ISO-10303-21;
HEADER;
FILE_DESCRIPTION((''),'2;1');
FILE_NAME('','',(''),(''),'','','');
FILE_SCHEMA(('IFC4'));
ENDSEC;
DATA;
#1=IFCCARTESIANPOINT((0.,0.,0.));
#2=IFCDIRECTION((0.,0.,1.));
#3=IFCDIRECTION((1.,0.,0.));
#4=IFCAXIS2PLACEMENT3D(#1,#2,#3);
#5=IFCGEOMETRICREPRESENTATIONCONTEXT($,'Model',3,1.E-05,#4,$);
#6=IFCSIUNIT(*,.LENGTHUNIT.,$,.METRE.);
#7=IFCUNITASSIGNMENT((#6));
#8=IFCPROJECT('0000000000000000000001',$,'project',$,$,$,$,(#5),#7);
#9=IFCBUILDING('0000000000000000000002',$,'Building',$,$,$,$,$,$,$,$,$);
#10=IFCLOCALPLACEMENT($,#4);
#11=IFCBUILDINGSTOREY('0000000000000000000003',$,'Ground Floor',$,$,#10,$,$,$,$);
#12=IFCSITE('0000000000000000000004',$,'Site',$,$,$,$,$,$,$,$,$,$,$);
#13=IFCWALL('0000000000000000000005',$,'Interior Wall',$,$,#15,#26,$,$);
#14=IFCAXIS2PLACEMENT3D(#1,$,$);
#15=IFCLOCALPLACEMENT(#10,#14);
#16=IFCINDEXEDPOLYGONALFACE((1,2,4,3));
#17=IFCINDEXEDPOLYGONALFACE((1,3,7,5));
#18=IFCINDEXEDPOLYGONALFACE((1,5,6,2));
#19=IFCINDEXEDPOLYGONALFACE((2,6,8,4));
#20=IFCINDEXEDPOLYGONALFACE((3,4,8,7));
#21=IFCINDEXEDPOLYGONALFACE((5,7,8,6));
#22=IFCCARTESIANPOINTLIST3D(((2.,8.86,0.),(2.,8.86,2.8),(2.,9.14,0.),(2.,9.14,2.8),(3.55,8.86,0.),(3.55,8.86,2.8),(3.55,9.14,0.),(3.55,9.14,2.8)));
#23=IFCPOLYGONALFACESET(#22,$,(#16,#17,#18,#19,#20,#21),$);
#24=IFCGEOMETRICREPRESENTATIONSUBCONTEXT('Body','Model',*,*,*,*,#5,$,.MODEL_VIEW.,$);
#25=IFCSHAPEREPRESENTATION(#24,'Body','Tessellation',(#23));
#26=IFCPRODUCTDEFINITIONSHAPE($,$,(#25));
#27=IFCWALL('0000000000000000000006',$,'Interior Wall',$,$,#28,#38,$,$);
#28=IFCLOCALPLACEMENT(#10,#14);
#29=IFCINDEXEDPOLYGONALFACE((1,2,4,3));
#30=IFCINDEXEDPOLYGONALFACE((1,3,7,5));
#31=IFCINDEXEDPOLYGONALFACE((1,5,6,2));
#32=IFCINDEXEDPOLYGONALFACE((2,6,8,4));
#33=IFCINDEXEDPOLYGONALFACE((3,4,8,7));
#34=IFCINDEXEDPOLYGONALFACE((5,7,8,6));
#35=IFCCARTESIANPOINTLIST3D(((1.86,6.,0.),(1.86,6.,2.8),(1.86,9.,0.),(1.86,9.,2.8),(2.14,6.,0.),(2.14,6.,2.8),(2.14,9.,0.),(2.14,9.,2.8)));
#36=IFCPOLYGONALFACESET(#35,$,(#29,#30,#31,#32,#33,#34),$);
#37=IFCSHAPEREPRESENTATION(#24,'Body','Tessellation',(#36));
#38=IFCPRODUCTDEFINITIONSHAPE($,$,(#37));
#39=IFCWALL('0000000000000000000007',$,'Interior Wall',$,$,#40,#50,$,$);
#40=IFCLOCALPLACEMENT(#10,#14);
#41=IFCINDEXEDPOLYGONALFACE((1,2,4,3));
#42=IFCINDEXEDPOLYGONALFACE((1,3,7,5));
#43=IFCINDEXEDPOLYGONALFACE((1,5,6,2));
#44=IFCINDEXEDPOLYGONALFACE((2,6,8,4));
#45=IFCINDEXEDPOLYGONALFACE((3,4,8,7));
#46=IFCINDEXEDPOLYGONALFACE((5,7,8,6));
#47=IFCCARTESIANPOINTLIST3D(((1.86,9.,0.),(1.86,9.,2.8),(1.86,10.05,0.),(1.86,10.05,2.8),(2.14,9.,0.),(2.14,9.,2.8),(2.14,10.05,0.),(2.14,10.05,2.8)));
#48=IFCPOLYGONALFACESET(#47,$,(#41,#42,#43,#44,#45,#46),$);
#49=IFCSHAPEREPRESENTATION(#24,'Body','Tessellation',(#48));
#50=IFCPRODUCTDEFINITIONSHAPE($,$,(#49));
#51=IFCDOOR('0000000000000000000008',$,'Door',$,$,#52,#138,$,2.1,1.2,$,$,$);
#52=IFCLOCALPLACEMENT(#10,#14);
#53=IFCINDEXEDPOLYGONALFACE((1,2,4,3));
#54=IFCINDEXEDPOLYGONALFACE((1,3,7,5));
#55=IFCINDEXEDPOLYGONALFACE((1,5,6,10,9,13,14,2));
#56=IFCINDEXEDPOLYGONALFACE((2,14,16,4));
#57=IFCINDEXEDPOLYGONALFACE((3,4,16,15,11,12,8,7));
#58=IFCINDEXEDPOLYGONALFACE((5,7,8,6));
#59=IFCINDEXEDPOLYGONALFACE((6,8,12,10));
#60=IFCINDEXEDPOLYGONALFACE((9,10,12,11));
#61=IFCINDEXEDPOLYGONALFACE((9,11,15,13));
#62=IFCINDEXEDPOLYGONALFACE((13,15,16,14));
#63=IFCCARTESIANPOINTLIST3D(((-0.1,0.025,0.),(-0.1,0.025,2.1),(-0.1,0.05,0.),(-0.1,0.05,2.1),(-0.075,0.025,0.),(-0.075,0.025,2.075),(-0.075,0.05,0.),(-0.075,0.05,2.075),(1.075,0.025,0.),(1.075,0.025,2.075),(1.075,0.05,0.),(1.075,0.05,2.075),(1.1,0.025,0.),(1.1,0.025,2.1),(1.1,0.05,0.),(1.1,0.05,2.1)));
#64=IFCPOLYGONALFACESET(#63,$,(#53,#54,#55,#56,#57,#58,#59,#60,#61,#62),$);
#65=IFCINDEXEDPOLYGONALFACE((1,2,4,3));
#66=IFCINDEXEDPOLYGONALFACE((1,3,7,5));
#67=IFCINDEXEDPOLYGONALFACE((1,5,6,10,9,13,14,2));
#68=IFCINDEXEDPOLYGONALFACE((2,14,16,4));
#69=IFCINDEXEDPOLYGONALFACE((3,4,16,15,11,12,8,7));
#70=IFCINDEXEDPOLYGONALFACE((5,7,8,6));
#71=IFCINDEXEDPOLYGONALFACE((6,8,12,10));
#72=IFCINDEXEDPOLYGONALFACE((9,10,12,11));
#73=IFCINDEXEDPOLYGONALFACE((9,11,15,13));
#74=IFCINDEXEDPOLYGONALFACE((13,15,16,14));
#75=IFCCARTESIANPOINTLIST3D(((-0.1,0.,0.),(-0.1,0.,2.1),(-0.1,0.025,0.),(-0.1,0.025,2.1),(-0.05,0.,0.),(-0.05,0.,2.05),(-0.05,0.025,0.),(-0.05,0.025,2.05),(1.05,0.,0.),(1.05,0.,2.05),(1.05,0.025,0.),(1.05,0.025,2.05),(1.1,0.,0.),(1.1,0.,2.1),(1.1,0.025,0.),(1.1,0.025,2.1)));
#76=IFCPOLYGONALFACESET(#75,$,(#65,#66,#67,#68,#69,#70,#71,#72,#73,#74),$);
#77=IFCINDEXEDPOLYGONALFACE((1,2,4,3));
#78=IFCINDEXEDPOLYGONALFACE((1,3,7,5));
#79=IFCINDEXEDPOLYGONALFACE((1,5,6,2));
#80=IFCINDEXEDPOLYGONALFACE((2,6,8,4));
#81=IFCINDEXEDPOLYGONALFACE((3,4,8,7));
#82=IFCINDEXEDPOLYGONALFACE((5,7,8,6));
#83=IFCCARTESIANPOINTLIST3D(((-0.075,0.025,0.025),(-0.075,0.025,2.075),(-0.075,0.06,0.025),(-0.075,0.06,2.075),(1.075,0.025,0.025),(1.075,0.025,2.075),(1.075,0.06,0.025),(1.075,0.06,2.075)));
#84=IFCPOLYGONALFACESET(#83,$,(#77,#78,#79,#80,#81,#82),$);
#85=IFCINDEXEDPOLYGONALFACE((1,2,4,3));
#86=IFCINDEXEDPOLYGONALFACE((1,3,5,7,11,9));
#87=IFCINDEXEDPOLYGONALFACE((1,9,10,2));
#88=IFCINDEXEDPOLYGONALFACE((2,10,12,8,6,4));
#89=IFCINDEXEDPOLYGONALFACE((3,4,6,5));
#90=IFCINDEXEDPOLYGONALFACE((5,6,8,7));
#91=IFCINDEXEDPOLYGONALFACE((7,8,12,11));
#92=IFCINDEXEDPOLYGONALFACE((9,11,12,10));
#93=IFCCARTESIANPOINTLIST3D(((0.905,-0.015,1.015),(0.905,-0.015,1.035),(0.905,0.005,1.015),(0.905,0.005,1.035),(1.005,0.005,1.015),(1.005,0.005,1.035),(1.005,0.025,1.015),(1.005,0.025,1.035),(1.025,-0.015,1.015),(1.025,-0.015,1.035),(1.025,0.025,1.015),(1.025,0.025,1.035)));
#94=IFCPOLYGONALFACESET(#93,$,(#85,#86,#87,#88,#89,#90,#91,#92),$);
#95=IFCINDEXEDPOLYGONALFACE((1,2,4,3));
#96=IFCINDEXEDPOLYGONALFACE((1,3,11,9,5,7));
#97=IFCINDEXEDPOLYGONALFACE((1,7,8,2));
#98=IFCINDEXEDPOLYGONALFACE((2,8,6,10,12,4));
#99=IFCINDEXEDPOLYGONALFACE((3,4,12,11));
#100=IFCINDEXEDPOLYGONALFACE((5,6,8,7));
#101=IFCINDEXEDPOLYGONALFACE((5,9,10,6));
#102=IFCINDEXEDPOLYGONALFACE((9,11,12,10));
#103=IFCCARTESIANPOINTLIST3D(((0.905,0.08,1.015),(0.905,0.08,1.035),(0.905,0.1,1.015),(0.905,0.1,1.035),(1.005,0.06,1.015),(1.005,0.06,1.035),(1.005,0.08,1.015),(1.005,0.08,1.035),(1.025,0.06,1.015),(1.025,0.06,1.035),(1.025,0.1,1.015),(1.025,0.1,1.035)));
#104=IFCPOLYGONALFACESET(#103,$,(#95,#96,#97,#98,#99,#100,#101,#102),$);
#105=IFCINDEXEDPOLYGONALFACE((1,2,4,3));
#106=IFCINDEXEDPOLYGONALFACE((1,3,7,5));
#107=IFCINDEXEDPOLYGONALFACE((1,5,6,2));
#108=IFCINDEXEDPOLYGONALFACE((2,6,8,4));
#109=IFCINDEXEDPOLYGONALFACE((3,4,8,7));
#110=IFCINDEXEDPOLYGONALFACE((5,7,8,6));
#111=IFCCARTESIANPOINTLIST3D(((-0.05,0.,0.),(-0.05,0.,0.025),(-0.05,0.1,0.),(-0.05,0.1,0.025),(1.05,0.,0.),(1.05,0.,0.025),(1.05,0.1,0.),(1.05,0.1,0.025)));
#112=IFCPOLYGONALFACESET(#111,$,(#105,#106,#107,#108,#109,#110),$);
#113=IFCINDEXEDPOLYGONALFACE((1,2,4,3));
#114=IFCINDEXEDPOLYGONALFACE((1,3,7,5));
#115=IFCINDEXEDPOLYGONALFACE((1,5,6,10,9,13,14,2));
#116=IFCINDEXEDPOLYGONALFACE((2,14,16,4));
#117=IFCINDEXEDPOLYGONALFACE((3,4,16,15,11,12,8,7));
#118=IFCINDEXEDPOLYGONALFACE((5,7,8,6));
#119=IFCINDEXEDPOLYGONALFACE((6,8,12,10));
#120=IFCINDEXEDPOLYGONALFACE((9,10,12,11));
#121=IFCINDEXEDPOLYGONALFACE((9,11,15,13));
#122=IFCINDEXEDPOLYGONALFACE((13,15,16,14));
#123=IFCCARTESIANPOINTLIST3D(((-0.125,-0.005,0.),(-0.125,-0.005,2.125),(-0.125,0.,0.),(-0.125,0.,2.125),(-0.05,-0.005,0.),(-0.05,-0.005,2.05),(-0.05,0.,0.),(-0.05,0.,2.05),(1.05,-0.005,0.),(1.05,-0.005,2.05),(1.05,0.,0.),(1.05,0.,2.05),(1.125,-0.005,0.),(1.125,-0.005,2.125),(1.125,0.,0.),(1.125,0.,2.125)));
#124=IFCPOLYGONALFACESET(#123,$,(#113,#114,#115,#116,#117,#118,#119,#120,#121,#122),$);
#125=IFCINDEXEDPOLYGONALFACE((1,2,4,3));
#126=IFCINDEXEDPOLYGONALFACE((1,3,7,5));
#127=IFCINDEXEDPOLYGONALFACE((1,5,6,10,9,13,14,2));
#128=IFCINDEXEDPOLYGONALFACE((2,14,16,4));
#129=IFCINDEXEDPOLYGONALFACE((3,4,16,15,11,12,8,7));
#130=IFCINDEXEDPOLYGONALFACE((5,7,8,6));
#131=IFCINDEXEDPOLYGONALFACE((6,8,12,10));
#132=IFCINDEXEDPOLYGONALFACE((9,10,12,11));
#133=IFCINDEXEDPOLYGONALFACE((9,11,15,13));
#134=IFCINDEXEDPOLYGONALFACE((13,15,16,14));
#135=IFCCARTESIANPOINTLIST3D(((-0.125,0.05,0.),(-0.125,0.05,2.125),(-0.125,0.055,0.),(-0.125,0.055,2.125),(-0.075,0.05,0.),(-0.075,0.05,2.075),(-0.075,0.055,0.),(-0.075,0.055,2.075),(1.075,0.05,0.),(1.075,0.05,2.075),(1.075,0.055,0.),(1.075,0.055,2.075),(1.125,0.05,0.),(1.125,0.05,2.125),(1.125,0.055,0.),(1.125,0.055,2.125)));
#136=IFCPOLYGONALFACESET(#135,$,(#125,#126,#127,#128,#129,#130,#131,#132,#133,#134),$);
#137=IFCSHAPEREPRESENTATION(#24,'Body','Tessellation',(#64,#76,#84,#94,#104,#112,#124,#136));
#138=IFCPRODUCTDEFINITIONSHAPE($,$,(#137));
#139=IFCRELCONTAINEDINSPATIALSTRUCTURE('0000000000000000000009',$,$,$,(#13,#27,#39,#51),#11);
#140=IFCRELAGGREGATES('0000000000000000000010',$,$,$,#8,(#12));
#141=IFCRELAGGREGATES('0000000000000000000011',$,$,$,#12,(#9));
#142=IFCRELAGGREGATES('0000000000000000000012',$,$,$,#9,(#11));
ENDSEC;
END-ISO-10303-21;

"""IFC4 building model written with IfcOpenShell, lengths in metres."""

from ifc_helpers import new_model, si_unit, frame, origin_with_axes, place, context, subcontext, project, spatial, line, indexed_curve, outline, extrude, element, save


model = new_model("IFC4")

# Units and contexts
model_context = context("Model", 3, precision=1e-05, world=origin_with_axes())
body_context = subcontext(model_context, "Body", "Model", "MODEL_VIEW")
ifc_project = project(units=[si_unit("LENGTHUNIT", "METRE")], contexts=[model_context])

# Site, building, storey
site = spatial("IfcSite", under=ifc_project, Name="Site")
building = spatial("IfcBuilding", under=site, Name="Building")
storey_placement = place(None, origin_with_axes())
storey = spatial("IfcBuildingStorey", under=building, at=storey_placement, Name="Ground Floor")

# Walls
wall_1_placement = place(storey_placement, frame((3.55, 9.0, 0.0), z_axis=(0.0, 0.0, 1.0), x_axis=(-1.0, 0.0, 0.0)))
element("IfcWall", 1, at=wall_1_placement, inside=storey, Name="Interior Wall", context=body_context, shape_type="SweptSolid", body=[
    extrude(outline(indexed_curve([(0.0, 0.0), (0.0, 0.28), (1.55, 0.28), (1.55, 0.0), (0.0, 0.0)], self_intersect=False)), frame((0.0, -0.14, 0.0), z_axis=(0.0, 0.0, 1.0), x_axis=(1.0, 0.0, 0.0)), (0.0, 0.0, 1.0), 2.8),
])
wall_2_placement = place(storey_placement, frame((2.0, 9.0, 0.0), z_axis=(0.0, 0.0, 1.0), x_axis=(0.0, -1.0, 0.0)))
element("IfcWall", 2, at=wall_2_placement, inside=storey, Name="Interior Wall", context=body_context, shape_type="SweptSolid", body=[
    extrude(outline(indexed_curve([(0.0, 0.0), (0.0, 0.28), (3.0, 0.28), (3.0, 0.0), (0.0, 0.0)], self_intersect=False)), frame((0.0, -0.14, 0.0), z_axis=(0.0, 0.0, 1.0), x_axis=(1.0, 0.0, 0.0)), (0.0, 0.0, 1.0), 2.8),
])
wall_3_placement = place(storey_placement, frame((2.0, 9.0, 0.0), z_axis=(0.0, 0.0, 1.0), x_axis=(0.0, 1.0, 0.0)))
element("IfcWall", 3, at=wall_3_placement, inside=storey, Name="Interior Wall", context=body_context, shape_type="SweptSolid", body=[
    extrude(outline(indexed_curve([(0.0, 0.0), (0.0, 0.28), (1.05, 0.28), (1.05, 0.0), (0.0, 0.0)], self_intersect=False)), frame((0.0, -0.14, 0.0), z_axis=(0.0, 0.0, 1.0), x_axis=(1.0, 0.0, 0.0)), (0.0, 0.0, 1.0), 2.8),
])

# Door
door_1_placement = place(storey_placement, frame((-0.1, 0.0, 0.0), z_axis=(0.0, 0.0, 1.0), x_axis=(1.0, 0.0, 0.0)))
element("IfcDoor", 4, at=door_1_placement, inside=storey, Name="Door", OverallHeight=2.1, OverallWidth=1.2, context=body_context, shape_type="SweptSolid", body=[
    extrude(outline(indexed_curve([(0.0, 0.0), (0.0, 2.1), (1.2, 2.1), (1.2, 0.0), (1.175, 0.0), (1.175, 2.075), (0.025, 2.075), (0.025, 0.0)], segments=[line(1, 2, 3, 4, 5, 6, 7, 8, 1)])), frame((0.0, 0.025, 0.0), z_axis=(0.0, -1.0, 0.0), x_axis=(1.0, 0.0, 0.0)), (0.0, 0.0, -1.0), 0.025),
    extrude(outline(indexed_curve([(0.0, 0.0), (0.0, 2.1), (1.2, 2.1), (1.2, 0.0), (1.15, 0.0), (1.15, 2.05), (0.05, 2.05), (0.05, 0.0)], segments=[line(1, 2, 3, 4, 5, 6, 7, 8, 1)])), frame((0.0, 0.0, 0.0), z_axis=(0.0, -1.0, 0.0), x_axis=(1.0, 0.0, 0.0)), (0.0, 0.0, -1.0), 0.025),
    extrude(outline(indexed_curve([(0.0, 0.0), (1.15, 0.0), (1.15, 0.035), (0.0, 0.035)], segments=[line(1, 2, 3, 4, 1)])), frame((0.025, 0.025, 0.025), z_axis=(0.0, 0.0, 1.0), x_axis=(1.0, 0.0, 0.0)), (0.0, 0.0, 1.0), 2.05),
    extrude(outline(indexed_curve([(0.0, 0.0), (0.0, -0.04), (-0.12, -0.04), (-0.12, -0.02), (-0.02, -0.02), (-0.02, 0.0)], segments=[line(1, 2, 3, 4, 5, 6, 1)])), frame((1.125, 0.025, 1.015), z_axis=(0.0, 0.0, 1.0), x_axis=(1.0, 0.0, 0.0)), (0.0, 0.0, 1.0), 0.02),
    extrude(outline(indexed_curve([(0.0, 0.0), (0.0, 0.04), (-0.12, 0.04), (-0.12, 0.02), (-0.02, 0.02), (-0.02, 0.0)], segments=[line(1, 2, 3, 4, 5, 6, 1)])), frame((1.125, 0.06, 1.015), z_axis=(0.0, 0.0, 1.0), x_axis=(1.0, 0.0, 0.0)), (0.0, 0.0, 1.0), 0.02),
    extrude(outline(indexed_curve([(0.0, 0.0), (1.1, 0.0), (1.1, 0.1), (0.0, 0.1)], segments=[line(1, 2, 3, 4, 1)])), frame((0.05, 0.0, 0.0), z_axis=(0.0, 0.0, 1.0), x_axis=(1.0, 0.0, 0.0)), (0.0, 0.0, 1.0), 0.025),
    extrude(outline(indexed_curve([(0.0, 0.0), (0.0, 2.125), (1.25, 2.125), (1.25, 0.0), (1.175, 0.0), (1.175, 2.05), (0.075, 2.05), (0.075, 0.0)], segments=[line(1, 2, 3, 4, 5, 6, 7, 8, 1)])), frame((-0.025, -0.005, 0.0), z_axis=(0.0, -1.0, 0.0), x_axis=(1.0, 0.0, 0.0)), (0.0, 0.0, -1.0), 0.005),
    extrude(outline(indexed_curve([(0.0, 0.0), (0.0, 2.125), (1.25, 2.125), (1.25, 0.0), (1.2, 0.0), (1.2, 2.075), (0.05, 2.075), (0.05, 0.0)], segments=[line(1, 2, 3, 4, 5, 6, 7, 8, 1)])), frame((-0.025, 0.05, 0.0), z_axis=(0.0, -1.0, 0.0), x_axis=(1.0, 0.0, 0.0)), (0.0, 0.0, -1.0), 0.005),
])

save(model, "model.ifc")
